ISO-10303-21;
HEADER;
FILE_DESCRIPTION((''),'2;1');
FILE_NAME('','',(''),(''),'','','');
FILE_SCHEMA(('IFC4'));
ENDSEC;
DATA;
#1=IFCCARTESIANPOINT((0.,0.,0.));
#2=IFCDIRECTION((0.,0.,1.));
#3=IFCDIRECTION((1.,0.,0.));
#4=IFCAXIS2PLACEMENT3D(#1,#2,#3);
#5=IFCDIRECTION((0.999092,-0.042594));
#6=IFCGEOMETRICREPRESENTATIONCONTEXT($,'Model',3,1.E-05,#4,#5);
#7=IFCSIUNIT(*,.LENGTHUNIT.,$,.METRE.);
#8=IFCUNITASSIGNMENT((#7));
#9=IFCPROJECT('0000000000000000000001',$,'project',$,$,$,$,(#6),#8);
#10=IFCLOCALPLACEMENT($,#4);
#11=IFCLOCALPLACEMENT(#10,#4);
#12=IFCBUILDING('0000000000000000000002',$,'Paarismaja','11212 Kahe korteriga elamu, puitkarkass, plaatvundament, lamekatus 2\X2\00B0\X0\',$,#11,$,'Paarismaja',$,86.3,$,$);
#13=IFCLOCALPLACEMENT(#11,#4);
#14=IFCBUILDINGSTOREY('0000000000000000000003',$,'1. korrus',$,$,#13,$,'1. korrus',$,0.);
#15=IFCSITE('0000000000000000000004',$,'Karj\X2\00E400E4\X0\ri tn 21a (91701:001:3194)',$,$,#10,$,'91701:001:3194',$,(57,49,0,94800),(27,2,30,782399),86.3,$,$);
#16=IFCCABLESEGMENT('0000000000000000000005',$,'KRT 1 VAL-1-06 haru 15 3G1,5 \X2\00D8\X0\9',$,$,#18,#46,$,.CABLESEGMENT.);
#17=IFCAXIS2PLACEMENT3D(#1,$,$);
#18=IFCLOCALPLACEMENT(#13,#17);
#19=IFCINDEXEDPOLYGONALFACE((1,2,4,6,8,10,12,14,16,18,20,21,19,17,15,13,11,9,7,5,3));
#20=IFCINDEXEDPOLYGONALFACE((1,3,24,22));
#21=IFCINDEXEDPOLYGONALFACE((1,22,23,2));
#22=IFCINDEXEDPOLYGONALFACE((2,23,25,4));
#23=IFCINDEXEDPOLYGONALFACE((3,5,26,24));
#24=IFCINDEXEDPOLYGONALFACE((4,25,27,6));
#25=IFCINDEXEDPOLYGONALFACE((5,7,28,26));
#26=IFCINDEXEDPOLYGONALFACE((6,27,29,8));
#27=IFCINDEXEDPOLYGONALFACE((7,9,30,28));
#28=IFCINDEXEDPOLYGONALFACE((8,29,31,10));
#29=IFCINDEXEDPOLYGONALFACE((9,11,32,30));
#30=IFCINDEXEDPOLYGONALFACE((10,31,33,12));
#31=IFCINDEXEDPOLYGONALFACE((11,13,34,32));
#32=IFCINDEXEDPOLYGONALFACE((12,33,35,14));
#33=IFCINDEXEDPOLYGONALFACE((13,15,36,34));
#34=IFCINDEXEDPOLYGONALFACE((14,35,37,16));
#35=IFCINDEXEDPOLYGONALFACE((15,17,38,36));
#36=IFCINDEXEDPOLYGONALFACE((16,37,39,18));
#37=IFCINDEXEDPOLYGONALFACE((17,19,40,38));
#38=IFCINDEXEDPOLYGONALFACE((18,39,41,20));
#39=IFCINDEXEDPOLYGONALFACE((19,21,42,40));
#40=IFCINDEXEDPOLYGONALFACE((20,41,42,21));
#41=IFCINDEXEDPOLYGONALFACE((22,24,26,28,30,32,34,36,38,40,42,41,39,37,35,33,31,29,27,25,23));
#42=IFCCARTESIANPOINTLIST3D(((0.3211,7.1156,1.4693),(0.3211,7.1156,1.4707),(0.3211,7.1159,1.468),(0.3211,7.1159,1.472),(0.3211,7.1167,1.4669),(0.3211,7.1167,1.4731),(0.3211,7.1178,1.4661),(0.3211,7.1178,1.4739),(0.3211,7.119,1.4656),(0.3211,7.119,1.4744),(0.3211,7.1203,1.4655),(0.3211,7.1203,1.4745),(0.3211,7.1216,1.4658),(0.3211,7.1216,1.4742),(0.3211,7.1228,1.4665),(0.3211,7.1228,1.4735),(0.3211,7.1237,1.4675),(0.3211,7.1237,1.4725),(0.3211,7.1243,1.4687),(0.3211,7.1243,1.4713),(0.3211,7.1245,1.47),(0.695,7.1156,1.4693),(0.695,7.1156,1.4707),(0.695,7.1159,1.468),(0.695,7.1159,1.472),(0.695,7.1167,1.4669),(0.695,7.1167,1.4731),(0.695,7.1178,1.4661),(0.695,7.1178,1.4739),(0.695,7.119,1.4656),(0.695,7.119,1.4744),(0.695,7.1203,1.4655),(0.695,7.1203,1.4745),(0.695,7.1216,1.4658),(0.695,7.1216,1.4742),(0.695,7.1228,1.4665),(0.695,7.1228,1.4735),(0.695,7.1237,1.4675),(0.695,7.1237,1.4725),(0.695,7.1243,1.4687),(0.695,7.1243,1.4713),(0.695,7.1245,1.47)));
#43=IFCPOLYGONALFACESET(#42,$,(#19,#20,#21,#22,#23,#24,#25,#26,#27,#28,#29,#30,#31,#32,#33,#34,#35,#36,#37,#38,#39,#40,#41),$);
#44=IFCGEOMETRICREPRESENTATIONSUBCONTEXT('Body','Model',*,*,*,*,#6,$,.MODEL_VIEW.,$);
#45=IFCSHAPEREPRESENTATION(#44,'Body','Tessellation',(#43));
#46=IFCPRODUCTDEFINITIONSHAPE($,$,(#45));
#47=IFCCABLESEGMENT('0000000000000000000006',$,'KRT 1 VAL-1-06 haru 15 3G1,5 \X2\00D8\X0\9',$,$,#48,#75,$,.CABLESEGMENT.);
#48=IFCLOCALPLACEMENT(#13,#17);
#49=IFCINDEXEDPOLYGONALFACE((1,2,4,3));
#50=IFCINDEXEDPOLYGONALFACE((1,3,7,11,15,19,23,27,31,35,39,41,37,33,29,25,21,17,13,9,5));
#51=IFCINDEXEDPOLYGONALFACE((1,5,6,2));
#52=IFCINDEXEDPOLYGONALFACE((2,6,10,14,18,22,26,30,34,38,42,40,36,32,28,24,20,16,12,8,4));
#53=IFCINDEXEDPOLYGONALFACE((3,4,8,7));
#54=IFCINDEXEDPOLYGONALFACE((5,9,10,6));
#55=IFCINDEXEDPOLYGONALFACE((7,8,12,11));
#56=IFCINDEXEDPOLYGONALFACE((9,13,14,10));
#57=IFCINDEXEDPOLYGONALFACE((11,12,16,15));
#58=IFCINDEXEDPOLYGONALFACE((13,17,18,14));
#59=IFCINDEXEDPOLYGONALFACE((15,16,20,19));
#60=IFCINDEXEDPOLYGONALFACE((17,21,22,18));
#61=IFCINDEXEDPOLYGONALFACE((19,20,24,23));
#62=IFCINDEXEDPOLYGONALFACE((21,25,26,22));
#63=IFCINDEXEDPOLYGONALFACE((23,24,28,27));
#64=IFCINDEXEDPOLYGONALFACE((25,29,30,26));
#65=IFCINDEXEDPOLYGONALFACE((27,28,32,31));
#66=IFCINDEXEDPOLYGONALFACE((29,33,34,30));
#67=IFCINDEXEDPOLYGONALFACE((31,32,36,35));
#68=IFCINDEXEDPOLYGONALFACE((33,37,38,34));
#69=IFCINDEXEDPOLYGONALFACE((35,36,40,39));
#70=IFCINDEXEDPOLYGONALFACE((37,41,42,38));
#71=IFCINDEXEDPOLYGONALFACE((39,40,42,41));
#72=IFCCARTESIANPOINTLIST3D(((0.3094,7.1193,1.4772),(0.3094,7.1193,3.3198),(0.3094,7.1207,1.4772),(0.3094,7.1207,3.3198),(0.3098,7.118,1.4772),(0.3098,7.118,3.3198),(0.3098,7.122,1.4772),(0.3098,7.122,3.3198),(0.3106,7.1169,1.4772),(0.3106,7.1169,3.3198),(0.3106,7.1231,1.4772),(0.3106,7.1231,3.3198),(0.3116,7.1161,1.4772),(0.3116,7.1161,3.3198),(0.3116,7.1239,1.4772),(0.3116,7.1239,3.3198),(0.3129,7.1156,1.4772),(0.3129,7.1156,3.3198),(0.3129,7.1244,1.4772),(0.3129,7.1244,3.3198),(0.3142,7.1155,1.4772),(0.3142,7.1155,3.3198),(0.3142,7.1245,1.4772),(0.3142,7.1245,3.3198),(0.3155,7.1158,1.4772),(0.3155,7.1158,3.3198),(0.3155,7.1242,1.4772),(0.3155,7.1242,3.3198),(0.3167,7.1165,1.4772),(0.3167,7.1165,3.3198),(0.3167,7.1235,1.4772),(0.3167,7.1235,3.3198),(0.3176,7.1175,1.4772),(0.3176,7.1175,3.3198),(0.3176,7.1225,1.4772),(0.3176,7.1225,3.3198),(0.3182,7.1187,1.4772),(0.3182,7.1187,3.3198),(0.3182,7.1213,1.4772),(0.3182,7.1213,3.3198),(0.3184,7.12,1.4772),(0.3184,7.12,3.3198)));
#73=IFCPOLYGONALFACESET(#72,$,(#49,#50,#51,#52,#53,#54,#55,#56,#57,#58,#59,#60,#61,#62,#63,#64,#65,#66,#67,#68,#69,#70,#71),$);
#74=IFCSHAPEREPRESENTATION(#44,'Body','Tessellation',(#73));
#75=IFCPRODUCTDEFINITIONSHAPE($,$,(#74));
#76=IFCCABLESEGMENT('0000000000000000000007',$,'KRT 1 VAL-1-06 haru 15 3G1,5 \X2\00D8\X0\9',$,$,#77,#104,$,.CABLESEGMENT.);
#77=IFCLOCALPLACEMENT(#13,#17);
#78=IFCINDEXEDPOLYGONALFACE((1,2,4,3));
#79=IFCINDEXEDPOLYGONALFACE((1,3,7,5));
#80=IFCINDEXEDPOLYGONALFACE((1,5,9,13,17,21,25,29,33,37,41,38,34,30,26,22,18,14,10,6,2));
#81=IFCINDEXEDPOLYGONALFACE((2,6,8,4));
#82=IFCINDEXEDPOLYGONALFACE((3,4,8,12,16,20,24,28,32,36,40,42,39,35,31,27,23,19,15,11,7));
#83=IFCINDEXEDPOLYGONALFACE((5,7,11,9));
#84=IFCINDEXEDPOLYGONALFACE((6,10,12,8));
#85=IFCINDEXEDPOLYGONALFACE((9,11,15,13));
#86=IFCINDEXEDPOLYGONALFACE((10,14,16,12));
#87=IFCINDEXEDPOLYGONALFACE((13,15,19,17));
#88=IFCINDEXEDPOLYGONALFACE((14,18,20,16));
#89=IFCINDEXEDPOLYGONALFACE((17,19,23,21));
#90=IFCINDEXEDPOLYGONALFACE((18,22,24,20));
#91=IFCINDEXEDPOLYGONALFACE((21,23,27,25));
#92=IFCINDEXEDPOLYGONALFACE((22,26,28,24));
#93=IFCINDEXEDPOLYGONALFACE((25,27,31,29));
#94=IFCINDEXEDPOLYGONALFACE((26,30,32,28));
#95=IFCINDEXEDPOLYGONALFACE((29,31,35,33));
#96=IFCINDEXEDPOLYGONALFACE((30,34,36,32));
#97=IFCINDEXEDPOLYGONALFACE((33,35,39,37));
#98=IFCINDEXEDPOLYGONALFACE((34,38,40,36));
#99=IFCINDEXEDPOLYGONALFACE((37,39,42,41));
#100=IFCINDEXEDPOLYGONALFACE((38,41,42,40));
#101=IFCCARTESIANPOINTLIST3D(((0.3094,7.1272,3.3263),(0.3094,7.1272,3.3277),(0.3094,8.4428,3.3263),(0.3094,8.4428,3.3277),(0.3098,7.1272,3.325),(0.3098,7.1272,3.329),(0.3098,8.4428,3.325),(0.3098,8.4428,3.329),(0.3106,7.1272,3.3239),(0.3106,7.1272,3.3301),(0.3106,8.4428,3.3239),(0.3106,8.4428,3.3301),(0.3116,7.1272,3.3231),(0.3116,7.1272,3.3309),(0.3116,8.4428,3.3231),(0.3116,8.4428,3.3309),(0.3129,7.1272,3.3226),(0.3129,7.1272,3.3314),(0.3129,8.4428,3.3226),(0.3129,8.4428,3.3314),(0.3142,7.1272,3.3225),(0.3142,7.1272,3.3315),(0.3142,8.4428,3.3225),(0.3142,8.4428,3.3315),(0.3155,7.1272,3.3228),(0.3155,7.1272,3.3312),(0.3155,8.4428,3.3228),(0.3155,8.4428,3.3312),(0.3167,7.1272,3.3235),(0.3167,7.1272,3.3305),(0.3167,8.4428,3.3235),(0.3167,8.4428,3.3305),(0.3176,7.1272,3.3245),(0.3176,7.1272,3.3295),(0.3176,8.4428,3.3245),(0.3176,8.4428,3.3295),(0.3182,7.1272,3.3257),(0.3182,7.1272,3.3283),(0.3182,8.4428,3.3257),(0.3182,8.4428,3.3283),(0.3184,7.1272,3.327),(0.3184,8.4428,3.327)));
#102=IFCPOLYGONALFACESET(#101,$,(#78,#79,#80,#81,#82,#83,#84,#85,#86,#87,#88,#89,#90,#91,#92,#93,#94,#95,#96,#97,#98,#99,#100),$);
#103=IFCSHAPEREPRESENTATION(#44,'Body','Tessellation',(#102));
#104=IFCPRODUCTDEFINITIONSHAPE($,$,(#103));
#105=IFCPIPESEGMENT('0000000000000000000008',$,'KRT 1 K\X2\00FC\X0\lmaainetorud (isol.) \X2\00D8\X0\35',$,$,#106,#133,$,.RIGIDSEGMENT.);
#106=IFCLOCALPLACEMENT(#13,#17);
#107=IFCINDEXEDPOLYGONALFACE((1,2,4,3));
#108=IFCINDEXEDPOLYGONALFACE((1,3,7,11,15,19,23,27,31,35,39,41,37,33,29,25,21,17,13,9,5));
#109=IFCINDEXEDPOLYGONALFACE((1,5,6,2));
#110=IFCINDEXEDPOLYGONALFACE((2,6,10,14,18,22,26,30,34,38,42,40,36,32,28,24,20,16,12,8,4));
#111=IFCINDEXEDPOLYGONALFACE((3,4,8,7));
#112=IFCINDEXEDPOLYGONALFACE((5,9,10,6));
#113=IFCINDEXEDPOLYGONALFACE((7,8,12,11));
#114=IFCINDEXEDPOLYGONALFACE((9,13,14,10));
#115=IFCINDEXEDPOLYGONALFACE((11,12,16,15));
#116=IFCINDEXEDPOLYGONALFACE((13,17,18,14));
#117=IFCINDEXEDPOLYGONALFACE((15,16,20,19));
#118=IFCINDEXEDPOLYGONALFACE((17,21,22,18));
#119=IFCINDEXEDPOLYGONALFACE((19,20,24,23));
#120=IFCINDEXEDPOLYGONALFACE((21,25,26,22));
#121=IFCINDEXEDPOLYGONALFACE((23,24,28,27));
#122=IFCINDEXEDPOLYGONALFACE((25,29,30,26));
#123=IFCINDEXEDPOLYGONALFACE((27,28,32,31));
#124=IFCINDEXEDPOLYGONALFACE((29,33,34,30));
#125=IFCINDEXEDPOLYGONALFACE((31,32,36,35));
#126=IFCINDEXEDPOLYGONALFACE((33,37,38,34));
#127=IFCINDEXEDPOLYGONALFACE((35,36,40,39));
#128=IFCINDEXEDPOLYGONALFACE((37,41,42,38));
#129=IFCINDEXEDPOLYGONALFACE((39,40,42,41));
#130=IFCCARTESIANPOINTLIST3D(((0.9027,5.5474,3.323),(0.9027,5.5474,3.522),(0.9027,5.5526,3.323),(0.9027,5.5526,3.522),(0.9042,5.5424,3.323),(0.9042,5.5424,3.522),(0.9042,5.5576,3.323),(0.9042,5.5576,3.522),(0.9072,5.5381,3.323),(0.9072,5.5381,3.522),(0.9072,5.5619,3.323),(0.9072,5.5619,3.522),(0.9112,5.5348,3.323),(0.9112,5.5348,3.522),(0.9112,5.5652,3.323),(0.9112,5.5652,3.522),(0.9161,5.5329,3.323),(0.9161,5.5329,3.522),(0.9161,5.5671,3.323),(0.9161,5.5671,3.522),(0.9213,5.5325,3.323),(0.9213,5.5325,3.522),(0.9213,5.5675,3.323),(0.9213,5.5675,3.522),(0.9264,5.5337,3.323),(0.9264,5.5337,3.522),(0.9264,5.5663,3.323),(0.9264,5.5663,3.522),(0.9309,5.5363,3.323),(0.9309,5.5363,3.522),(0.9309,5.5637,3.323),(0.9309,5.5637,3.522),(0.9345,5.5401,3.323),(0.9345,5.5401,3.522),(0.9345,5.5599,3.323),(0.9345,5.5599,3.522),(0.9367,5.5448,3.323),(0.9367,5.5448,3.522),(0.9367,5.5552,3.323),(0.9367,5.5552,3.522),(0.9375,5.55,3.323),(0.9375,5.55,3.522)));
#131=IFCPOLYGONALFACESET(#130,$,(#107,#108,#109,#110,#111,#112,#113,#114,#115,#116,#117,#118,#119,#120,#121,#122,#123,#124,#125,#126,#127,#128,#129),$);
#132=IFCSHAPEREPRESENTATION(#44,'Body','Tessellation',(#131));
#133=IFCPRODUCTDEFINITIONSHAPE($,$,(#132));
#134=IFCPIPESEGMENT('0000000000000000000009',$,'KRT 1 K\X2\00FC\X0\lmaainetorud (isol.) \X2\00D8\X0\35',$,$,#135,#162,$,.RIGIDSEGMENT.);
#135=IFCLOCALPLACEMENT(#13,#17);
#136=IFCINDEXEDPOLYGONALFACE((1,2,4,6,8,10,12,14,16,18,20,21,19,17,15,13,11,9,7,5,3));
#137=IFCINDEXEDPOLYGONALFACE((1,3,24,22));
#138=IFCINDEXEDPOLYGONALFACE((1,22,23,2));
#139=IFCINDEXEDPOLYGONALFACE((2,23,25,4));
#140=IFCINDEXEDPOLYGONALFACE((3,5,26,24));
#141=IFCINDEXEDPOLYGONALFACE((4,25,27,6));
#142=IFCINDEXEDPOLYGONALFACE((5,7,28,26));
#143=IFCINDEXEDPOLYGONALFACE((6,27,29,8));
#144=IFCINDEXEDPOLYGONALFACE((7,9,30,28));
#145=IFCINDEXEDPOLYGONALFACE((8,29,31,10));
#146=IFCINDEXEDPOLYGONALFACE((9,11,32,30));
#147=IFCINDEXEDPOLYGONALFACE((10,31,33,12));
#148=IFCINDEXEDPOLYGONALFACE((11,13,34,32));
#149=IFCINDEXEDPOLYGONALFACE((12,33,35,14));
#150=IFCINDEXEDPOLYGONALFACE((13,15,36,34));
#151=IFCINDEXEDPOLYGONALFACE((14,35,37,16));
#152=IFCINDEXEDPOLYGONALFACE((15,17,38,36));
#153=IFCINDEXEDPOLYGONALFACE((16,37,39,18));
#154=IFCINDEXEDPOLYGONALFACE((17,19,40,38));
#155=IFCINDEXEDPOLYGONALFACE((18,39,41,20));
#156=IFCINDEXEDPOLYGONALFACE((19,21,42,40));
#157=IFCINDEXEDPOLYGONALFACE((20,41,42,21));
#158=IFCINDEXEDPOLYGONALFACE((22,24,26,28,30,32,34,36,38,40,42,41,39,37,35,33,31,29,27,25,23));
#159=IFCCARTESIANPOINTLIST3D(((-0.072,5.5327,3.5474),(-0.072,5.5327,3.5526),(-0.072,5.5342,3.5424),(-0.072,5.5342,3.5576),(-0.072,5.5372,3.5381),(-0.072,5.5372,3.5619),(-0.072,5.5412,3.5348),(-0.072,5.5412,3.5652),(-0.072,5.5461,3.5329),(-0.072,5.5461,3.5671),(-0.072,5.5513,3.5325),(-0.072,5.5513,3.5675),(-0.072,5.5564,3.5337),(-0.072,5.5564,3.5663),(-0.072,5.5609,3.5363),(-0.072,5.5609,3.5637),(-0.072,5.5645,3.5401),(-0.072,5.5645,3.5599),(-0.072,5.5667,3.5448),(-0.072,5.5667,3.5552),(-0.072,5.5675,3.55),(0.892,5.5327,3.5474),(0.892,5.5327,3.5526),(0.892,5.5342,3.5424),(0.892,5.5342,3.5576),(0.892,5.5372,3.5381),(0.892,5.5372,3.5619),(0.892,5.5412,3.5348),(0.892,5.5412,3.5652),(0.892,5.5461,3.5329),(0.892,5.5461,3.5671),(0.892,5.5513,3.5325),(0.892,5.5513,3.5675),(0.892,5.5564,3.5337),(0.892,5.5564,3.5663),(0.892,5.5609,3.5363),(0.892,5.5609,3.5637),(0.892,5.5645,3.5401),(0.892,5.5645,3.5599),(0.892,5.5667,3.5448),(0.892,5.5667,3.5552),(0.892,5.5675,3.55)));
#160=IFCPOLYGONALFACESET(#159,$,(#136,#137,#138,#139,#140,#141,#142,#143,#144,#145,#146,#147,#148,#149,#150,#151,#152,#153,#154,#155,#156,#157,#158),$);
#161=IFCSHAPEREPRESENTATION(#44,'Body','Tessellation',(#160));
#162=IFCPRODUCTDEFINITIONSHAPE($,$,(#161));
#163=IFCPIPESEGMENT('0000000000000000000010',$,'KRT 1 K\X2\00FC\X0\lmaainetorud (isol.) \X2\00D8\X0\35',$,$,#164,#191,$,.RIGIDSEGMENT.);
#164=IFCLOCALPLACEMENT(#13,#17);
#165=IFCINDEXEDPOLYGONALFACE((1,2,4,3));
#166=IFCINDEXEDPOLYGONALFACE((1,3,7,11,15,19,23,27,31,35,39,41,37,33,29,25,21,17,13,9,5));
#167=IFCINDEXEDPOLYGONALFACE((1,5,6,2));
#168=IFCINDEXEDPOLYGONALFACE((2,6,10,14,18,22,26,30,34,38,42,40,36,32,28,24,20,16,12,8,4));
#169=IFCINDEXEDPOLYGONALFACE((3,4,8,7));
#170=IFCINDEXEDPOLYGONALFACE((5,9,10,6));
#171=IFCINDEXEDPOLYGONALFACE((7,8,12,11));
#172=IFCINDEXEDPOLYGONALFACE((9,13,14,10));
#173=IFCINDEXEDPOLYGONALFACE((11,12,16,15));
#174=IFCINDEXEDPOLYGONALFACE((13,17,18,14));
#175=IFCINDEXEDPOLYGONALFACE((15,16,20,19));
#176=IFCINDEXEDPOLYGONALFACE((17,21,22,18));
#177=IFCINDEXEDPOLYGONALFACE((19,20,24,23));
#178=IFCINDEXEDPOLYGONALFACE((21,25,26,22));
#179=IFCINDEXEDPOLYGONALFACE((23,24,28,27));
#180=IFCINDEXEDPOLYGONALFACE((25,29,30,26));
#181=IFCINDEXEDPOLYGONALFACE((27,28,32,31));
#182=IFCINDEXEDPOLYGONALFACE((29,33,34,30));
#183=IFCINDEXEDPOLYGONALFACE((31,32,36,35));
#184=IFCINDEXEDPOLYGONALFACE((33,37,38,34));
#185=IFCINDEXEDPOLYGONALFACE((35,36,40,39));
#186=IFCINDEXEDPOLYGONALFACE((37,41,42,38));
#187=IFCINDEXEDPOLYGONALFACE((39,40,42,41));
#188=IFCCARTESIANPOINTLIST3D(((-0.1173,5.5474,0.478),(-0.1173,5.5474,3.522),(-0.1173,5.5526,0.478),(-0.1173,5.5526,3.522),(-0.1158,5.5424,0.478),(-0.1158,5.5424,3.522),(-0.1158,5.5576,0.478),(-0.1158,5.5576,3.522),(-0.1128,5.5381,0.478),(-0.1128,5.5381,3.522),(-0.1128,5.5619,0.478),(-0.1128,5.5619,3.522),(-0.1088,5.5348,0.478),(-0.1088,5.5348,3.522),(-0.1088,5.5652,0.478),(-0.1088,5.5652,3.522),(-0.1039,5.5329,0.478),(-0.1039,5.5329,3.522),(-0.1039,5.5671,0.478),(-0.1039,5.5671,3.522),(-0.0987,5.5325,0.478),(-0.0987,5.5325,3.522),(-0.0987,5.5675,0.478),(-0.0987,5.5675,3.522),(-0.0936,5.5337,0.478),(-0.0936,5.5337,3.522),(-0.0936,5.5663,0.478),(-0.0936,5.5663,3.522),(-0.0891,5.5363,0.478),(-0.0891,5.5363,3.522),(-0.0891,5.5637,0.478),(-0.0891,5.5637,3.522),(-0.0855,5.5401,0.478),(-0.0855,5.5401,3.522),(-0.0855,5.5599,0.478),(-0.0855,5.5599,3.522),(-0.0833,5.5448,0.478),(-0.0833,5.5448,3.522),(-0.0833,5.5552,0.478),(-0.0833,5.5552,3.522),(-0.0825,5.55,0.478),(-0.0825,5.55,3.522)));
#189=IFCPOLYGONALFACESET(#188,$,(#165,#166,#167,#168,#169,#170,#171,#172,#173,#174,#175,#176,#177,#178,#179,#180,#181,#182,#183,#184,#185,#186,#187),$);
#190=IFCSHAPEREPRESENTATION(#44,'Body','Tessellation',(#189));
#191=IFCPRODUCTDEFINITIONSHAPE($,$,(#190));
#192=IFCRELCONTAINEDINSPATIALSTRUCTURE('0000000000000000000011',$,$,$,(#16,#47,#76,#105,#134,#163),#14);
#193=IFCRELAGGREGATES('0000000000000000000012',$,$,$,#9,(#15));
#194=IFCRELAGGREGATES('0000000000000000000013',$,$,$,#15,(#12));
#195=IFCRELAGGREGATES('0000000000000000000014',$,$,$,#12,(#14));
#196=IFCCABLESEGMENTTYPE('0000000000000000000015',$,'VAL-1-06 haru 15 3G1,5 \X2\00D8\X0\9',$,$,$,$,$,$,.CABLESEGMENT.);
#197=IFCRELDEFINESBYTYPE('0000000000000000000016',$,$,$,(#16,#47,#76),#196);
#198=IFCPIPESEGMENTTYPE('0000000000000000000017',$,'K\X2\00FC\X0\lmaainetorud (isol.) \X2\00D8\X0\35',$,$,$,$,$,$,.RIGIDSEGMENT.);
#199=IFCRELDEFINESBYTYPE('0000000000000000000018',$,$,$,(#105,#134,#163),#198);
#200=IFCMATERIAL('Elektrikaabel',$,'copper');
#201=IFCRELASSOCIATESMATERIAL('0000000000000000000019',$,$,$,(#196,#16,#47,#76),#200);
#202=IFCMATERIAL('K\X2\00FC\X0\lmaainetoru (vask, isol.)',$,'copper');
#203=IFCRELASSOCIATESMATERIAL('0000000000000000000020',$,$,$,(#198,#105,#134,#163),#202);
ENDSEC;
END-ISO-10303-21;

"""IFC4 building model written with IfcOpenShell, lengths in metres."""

from ifc_helpers import new_model, si_unit, direction, frame, origin_with_axes, place, context, subcontext, project, spatial, circle, extrude, material, type_object, element, save


model = new_model("IFC4")

# Units and contexts
model_context = context("Model", 3, precision=1e-05, world=origin_with_axes(), true_north=direction((0.999092, -0.042594)))
body_context = subcontext(model_context, "Body", "Model", "MODEL_VIEW")
ifc_project = project(units=[si_unit("LENGTHUNIT", "METRE")], contexts=[model_context])

# Site, building, storey
site_placement = place(None, origin_with_axes())
site = spatial("IfcSite", under=ifc_project, at=site_placement, Name="Karjääri tn 21a (91701:001:3194)", LongName="91701:001:3194", RefLatitude=(57, 49, 0, 94800), RefLongitude=(27, 2, 30, 782399), RefElevation=86.3)
building_placement = place(site_placement, origin_with_axes())
building = spatial("IfcBuilding", under=site, at=building_placement, Name="Paarismaja", Description="11212 Kahe korteriga elamu, puitkarkass, plaatvundament, lamekatus 2°", LongName="Paarismaja", ElevationOfRefHeight=86.3)
storey_placement = place(building_placement, origin_with_axes())
storey = spatial("IfcBuildingStorey", under=building, at=storey_placement, Name="1. korrus", LongName="1. korrus", Elevation=0.0)

# Shared definitions
ifc_material_1 = material(Name="Elektrikaabel", Category="copper")

# Shared definitions
ifc_material_2 = material(Name="Külmaainetoru (vask, isol.)", Category="copper")

# Cable segments
cable_segment_type_1 = type_object("IfcCableSegmentType", Name="VAL-1-06 haru 15 3G1,5 Ø9", PredefinedType="CABLESEGMENT", material=ifc_material_1)
cable_segment_1_placement = place(storey_placement, frame((0.695, 7.12, 1.47), z_axis=(-1.0, 0.0, 0.0), x_axis=(0.0, 1.0, 0.0)))
element("IfcCableSegment", 1, at=cable_segment_1_placement, inside=storey, type_object=cable_segment_type_1, material=ifc_material_1, Name="KRT 1 VAL-1-06 haru 15 3G1,5 Ø9", PredefinedType="CABLESEGMENT", context=body_context, shape_type="SweptSolid", body=[
    extrude(circle(Radius=0.0045), origin_with_axes(), (0.0, 0.0, 1.0), 0.3739),
])
cable_segment_2_placement = place(storey_placement, frame((0.3139, 7.12, 1.4772), z_axis=(0.0, 0.0, 1.0), x_axis=(1.0, 0.0, 0.0)))
element("IfcCableSegment", 2, at=cable_segment_2_placement, inside=storey, type_object=cable_segment_type_1, material=ifc_material_1, Name="KRT 1 VAL-1-06 haru 15 3G1,5 Ø9", PredefinedType="CABLESEGMENT", context=body_context, shape_type="SweptSolid", body=[
    extrude(circle(Radius=0.0045), origin_with_axes(), (0.0, 0.0, 1.0), 1.8426),
])
cable_segment_3_placement = place(storey_placement, frame((0.3139, 7.1272, 3.327), z_axis=(0.0, 1.0, 0.0), x_axis=(1.0, 0.0, 0.0)))
element("IfcCableSegment", 3, at=cable_segment_3_placement, inside=storey, type_object=cable_segment_type_1, material=ifc_material_1, Name="KRT 1 VAL-1-06 haru 15 3G1,5 Ø9", PredefinedType="CABLESEGMENT", context=body_context, shape_type="SweptSolid", body=[
    extrude(circle(Radius=0.0045), origin_with_axes(), (0.0, 0.0, 1.0), 1.3156),
])

# Pipe segments
pipe_segment_type_1 = type_object("IfcPipeSegmentType", Name="Külmaainetorud (isol.) Ø35", PredefinedType="RIGIDSEGMENT", material=ifc_material_2)
pipe_segment_1_placement = place(storey_placement, frame((0.92, 5.55, 3.323), z_axis=(0.0, 0.0, 1.0), x_axis=(1.0, 0.0, 0.0)))
element("IfcPipeSegment", 4, at=pipe_segment_1_placement, inside=storey, type_object=pipe_segment_type_1, material=ifc_material_2, Name="KRT 1 Külmaainetorud (isol.) Ø35", PredefinedType="RIGIDSEGMENT", context=body_context, shape_type="SweptSolid", body=[
    extrude(circle(Radius=0.0175), origin_with_axes(), (0.0, 0.0, 1.0), 0.199),
])
pipe_segment_2_placement = place(storey_placement, frame((0.892, 5.55, 3.55), z_axis=(-1.0, 0.0, 0.0), x_axis=(0.0, 1.0, 0.0)))
element("IfcPipeSegment", 5, at=pipe_segment_2_placement, inside=storey, type_object=pipe_segment_type_1, material=ifc_material_2, Name="KRT 1 Külmaainetorud (isol.) Ø35", PredefinedType="RIGIDSEGMENT", context=body_context, shape_type="SweptSolid", body=[
    extrude(circle(Radius=0.0175), origin_with_axes(), (0.0, 0.0, 1.0), 0.964),
])
pipe_segment_3_placement = place(storey_placement, frame((-0.1, 5.55, 3.522), z_axis=(0.0, 0.0, -1.0), x_axis=(1.0, 0.0, 0.0)))
element("IfcPipeSegment", 6, at=pipe_segment_3_placement, inside=storey, type_object=pipe_segment_type_1, material=ifc_material_2, Name="KRT 1 Külmaainetorud (isol.) Ø35", PredefinedType="RIGIDSEGMENT", context=body_context, shape_type="SweptSolid", body=[
    extrude(circle(Radius=0.0175), origin_with_axes(), (0.0, 0.0, 1.0), 3.044),
])

save(model, "model.ifc")
